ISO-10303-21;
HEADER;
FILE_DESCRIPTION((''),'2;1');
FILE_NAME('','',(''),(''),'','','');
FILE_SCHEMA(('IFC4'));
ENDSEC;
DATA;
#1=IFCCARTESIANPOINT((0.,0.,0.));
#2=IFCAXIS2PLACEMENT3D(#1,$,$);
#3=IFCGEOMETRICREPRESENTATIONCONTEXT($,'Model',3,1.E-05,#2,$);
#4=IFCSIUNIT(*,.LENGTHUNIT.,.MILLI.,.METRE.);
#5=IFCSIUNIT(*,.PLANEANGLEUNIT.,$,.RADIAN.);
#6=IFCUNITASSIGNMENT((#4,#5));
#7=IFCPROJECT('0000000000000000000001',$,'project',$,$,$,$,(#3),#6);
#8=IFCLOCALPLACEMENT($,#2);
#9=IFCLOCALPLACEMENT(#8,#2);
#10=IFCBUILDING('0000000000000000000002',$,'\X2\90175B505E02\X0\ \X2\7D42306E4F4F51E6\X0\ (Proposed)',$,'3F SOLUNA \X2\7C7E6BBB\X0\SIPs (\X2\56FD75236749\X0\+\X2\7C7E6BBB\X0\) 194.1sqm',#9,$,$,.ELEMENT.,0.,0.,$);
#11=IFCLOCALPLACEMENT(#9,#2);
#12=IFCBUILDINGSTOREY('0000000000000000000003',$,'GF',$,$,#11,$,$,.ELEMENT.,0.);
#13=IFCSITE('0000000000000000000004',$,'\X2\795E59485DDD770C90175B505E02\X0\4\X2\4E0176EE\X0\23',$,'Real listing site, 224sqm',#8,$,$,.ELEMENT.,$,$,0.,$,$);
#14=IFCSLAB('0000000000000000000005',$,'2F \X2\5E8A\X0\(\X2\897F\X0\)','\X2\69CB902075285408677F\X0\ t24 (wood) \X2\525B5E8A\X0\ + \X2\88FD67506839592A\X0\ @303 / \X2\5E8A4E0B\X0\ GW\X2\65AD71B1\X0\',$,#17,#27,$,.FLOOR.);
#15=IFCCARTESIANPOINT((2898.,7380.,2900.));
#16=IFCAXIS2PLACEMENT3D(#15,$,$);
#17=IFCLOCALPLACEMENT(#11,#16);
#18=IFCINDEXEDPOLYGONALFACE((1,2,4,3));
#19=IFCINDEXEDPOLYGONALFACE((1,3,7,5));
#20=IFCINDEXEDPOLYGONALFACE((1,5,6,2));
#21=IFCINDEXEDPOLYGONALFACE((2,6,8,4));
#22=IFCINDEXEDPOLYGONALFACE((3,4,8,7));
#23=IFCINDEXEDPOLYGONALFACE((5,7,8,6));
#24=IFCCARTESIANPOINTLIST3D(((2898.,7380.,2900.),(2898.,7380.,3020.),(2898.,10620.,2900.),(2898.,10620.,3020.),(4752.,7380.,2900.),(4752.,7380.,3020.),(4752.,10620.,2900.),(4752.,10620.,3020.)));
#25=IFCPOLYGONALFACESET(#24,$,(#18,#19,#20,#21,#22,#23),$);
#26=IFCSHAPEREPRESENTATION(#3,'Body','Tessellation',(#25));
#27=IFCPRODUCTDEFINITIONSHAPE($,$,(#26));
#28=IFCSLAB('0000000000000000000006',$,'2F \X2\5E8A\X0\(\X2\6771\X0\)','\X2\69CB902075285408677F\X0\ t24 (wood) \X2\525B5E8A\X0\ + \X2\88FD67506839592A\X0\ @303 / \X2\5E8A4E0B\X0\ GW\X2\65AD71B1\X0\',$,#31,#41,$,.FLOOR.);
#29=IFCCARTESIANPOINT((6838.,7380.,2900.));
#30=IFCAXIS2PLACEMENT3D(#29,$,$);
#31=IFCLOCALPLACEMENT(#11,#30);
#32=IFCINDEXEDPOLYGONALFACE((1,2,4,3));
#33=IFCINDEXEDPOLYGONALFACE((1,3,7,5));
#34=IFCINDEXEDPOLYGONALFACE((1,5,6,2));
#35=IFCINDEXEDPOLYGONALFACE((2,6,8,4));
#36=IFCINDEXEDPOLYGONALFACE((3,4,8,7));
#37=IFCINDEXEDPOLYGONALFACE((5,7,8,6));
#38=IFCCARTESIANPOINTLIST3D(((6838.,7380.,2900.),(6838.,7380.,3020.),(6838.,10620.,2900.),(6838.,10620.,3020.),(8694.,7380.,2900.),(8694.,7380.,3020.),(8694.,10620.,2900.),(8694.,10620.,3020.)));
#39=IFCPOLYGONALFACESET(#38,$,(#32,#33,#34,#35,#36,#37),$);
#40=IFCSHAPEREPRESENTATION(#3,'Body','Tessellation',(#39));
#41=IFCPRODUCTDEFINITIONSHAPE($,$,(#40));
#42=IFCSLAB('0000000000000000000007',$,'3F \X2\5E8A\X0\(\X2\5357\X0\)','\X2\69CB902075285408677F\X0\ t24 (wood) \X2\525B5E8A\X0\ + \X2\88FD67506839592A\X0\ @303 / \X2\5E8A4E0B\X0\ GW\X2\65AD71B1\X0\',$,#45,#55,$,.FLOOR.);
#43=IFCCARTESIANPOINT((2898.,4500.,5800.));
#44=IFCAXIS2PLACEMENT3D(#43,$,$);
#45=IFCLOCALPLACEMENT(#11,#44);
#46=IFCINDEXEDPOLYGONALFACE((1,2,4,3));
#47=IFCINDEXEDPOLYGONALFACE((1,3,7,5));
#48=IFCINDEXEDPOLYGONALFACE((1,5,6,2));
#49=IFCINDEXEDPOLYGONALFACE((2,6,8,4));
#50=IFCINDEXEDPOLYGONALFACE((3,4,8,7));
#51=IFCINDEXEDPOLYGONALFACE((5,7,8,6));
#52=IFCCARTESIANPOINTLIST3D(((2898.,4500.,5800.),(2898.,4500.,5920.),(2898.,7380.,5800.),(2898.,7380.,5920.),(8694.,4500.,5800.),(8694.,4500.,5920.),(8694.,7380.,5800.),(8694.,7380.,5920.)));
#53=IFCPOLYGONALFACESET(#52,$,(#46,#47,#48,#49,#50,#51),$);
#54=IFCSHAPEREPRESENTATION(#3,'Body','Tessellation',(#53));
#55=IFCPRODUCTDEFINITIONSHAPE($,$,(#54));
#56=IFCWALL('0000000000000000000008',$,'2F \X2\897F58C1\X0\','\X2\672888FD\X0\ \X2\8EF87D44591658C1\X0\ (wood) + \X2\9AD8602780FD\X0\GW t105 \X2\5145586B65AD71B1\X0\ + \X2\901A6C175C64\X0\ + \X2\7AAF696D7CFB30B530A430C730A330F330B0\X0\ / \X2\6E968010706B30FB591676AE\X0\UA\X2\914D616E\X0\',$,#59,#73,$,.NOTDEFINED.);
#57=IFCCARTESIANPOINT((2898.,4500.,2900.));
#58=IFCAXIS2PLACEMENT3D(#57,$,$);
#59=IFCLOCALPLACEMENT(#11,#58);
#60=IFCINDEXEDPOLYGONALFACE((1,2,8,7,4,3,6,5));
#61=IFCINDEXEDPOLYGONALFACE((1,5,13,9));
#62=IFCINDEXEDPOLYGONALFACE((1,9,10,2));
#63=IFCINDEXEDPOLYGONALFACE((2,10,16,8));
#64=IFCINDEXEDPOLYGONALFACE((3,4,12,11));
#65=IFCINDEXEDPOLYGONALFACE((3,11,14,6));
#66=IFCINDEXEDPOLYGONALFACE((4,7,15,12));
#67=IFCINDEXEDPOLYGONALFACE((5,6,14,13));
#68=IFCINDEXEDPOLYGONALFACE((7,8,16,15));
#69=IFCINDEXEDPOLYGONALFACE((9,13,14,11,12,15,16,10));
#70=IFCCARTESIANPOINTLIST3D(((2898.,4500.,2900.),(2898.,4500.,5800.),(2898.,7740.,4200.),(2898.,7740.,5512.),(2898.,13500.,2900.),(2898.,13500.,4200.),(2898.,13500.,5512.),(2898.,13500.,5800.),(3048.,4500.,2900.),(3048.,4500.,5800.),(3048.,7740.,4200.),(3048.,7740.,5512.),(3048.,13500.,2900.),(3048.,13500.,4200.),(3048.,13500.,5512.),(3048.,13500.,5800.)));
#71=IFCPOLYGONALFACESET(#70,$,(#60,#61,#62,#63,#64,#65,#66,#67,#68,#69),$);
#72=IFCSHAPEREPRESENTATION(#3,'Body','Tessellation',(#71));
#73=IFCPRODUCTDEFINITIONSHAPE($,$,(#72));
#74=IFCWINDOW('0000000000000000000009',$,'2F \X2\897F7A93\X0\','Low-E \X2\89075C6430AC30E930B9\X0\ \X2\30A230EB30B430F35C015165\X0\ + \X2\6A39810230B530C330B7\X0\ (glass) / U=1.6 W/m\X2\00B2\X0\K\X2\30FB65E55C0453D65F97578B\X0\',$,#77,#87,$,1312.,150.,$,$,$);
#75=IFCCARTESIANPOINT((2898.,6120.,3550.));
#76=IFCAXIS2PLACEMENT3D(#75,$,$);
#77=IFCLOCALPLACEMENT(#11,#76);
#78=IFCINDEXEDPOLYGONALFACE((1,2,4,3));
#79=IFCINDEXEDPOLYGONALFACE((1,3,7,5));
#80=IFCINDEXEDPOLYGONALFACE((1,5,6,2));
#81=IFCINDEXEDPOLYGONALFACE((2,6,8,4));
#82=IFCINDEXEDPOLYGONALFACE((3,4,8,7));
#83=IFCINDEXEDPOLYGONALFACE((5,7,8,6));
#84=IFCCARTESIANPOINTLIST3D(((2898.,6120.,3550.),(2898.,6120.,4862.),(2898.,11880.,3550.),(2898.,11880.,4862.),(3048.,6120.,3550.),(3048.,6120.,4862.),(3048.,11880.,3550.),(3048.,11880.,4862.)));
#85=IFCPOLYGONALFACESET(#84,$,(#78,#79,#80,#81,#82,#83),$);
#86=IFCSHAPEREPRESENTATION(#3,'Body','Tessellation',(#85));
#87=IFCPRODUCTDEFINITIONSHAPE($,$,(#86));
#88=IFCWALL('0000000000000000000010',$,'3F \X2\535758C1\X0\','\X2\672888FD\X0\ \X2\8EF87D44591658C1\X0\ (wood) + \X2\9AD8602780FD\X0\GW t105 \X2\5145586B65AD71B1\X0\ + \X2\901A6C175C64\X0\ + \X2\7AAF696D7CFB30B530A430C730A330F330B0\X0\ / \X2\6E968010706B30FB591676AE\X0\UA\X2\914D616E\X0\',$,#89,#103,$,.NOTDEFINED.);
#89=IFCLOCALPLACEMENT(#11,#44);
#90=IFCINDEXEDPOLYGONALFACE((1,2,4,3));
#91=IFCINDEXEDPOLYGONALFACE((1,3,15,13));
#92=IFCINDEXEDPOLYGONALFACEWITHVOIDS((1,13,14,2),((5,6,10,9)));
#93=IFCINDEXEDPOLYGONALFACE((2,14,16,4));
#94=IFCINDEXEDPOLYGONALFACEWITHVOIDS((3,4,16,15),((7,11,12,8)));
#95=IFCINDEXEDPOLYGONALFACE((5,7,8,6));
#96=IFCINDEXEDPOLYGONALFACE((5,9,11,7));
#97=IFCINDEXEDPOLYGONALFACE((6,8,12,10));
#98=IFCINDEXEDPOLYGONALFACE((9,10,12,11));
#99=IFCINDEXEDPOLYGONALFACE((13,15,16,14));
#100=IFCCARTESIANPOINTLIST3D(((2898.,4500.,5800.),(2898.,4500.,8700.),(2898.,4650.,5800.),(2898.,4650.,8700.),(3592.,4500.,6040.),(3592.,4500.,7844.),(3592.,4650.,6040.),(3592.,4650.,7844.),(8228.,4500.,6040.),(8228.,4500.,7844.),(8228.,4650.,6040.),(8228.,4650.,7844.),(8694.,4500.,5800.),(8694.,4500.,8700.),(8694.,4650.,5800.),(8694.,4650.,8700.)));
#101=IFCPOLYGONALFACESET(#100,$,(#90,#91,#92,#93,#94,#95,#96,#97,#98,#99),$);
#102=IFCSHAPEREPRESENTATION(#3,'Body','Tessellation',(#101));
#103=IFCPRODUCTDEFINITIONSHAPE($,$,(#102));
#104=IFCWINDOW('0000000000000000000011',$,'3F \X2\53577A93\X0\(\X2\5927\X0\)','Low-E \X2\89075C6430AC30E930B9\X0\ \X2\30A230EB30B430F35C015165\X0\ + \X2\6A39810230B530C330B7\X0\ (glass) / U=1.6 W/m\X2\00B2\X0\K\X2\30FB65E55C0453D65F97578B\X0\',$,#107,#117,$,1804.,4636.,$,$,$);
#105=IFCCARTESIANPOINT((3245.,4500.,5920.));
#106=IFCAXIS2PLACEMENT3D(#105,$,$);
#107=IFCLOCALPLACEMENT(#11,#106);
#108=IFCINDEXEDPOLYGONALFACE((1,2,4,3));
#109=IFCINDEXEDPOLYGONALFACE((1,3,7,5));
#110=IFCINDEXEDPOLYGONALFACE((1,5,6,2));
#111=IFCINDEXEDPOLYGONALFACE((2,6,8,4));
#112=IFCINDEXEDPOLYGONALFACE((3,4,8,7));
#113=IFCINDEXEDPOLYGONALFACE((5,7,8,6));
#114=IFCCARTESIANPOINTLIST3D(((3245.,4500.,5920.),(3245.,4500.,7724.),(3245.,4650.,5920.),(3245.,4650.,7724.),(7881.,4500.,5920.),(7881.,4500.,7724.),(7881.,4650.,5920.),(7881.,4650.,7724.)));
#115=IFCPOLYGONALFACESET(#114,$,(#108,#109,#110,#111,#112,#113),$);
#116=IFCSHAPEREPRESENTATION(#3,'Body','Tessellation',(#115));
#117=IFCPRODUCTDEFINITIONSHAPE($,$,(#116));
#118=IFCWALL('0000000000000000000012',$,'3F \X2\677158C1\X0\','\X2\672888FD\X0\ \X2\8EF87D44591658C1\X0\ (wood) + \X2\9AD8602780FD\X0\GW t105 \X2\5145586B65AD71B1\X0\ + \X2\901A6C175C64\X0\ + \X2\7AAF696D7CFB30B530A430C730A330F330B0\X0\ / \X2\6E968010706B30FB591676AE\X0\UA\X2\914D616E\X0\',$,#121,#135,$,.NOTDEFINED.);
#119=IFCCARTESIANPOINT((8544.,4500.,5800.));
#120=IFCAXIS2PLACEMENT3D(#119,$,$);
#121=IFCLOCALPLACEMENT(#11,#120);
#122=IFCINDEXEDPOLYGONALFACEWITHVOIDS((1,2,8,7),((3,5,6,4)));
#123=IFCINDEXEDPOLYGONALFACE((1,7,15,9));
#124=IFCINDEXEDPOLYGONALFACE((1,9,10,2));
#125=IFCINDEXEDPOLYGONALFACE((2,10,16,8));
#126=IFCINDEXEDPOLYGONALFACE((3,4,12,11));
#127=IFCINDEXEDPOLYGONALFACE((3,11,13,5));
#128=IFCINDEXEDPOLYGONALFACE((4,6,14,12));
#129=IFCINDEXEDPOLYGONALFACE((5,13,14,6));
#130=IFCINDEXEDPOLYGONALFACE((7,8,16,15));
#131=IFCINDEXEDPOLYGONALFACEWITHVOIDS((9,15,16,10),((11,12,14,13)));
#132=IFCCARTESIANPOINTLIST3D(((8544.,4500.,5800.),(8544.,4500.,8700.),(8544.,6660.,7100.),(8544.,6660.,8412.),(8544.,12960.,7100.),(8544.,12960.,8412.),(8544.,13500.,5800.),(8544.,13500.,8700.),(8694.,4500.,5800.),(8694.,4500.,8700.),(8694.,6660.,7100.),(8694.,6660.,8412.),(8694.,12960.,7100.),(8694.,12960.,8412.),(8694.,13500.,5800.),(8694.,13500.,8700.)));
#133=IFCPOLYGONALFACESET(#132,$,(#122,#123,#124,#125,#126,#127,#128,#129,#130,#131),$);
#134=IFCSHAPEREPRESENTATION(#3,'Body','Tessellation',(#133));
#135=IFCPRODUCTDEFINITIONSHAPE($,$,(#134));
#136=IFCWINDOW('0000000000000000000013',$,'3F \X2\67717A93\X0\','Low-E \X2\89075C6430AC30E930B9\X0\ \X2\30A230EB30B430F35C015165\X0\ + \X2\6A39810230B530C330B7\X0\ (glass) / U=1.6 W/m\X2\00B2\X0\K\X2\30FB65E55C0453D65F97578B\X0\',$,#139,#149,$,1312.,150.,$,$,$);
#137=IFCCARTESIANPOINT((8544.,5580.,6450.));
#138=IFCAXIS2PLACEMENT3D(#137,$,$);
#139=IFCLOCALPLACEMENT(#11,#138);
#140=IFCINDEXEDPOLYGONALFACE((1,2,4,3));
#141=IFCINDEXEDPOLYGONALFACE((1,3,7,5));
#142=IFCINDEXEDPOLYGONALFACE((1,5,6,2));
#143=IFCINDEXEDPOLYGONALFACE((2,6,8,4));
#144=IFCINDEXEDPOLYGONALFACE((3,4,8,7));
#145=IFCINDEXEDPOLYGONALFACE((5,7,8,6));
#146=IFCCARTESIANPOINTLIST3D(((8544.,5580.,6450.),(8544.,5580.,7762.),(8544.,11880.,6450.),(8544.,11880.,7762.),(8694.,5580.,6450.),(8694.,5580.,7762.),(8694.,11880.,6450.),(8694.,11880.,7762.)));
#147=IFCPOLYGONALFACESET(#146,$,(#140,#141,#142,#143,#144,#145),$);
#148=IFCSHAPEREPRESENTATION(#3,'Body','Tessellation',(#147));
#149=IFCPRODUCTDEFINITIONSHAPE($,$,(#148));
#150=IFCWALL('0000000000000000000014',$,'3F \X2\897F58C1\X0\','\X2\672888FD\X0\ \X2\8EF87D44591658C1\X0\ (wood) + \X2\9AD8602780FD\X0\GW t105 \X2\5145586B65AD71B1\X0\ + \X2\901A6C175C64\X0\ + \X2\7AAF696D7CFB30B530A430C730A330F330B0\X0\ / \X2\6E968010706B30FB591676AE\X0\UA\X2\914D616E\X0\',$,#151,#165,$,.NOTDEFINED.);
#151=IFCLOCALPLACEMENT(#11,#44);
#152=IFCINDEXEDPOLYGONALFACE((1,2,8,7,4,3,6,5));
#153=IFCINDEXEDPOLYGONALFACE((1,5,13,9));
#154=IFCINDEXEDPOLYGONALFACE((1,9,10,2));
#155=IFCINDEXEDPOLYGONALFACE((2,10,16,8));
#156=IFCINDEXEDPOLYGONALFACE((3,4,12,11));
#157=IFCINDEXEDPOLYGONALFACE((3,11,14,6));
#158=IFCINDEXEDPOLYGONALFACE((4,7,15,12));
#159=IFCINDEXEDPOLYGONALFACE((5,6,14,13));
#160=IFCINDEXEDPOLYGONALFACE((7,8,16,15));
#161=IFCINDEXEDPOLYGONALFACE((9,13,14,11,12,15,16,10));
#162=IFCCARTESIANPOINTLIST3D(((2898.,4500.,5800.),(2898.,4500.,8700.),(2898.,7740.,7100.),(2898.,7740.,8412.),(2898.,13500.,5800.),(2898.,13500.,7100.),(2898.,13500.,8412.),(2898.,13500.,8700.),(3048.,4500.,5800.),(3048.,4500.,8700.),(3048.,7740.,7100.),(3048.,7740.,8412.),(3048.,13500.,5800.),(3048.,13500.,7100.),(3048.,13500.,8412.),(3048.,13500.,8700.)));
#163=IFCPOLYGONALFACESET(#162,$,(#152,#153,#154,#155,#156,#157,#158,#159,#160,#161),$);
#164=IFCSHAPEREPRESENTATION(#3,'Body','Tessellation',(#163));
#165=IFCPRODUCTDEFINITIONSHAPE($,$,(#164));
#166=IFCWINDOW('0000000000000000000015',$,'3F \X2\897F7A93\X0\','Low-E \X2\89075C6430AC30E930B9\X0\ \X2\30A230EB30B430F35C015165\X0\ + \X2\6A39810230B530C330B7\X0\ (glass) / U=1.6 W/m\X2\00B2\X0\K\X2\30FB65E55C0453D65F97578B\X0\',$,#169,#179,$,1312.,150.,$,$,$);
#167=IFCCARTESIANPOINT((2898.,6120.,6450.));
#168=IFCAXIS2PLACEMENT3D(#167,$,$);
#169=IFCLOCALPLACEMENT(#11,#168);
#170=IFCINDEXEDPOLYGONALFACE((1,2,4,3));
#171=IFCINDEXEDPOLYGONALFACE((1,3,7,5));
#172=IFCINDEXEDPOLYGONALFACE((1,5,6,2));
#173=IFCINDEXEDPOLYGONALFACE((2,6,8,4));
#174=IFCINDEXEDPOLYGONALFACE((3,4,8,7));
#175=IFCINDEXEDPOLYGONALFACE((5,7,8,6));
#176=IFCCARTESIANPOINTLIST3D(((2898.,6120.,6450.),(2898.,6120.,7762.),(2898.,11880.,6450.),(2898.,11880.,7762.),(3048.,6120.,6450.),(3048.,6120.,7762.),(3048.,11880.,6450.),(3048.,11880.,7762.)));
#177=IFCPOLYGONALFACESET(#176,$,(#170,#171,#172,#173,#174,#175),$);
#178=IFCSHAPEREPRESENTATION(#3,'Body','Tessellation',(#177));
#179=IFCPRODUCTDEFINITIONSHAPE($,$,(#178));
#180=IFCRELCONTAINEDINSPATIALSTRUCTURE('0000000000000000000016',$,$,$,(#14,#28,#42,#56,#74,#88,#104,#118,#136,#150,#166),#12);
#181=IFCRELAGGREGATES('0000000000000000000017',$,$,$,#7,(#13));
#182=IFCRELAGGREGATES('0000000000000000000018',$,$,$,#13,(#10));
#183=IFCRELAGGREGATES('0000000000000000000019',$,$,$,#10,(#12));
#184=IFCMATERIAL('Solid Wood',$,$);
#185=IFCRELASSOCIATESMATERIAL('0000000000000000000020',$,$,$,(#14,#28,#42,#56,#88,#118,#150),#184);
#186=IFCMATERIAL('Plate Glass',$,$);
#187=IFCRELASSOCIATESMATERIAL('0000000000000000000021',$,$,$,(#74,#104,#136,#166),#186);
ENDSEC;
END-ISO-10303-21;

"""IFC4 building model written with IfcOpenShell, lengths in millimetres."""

from ifc_helpers import new_model, si_unit, frame, frame_2d, origin, place, context, project, spatial, rectangle, extrude, material, element, fill, save


model = new_model("IFC4")

# Units and contexts
model_context = context("Model", 3, precision=1e-05, world=origin())
ifc_project = project(units=[si_unit("LENGTHUNIT", "METRE", prefix="MILLI"), si_unit("PLANEANGLEUNIT", "RADIAN")], contexts=[model_context])

# Site, building, storey
site_placement = place(None, origin())
site = spatial("IfcSite", under=ifc_project, at=site_placement, Name="神奈川県逗子市4丁目23", ObjectType="Real listing site, 224sqm", CompositionType="ELEMENT", RefElevation=0.0)
building_placement = place(site_placement, origin())
building = spatial("IfcBuilding", under=site, at=building_placement, Name="逗子市 終の住処 (Proposed)", ObjectType="3F SOLUNA 籾殻SIPs (国産杉+籾殻) 194.1sqm", CompositionType="ELEMENT", ElevationOfRefHeight=0.0, ElevationOfTerrain=0.0)
storey_placement = place(building_placement, origin())
storey = spatial("IfcBuildingStorey", under=building, at=storey_placement, Name="GF", CompositionType="ELEMENT", Elevation=0.0)

# Slabs
ifc_material_1 = material(Name="Solid Wood")
slab_1_placement = place(storey_placement, frame((2898.0, 7380.0, 2900.0)))
element("IfcSlab", 1, at=slab_1_placement, inside=storey, material=ifc_material_1, Name="2F 床(西)", Description="構造用合板 t24 (wood) 剛床 + 製材根太 @303 / 床下 GW断熱", PredefinedType="FLOOR", context=model_context, shape_type="SweptSolid", body=[
    extrude(rectangle(XDim=1854.0, YDim=3240.0, at=frame_2d((927.0, 1620.0))), frame((2898.0, 7380.0, 2900.0)), (0.0, 0.0, 1.0), 120.0),
])
slab_2_placement = place(storey_placement, frame((6838.0, 7380.0, 2900.0)))
element("IfcSlab", 2, at=slab_2_placement, inside=storey, material=ifc_material_1, Name="2F 床(東)", Description="構造用合板 t24 (wood) 剛床 + 製材根太 @303 / 床下 GW断熱", PredefinedType="FLOOR", context=model_context, shape_type="SweptSolid", body=[
    extrude(rectangle(XDim=1856.0, YDim=3240.0, at=frame_2d((928.0, 1620.0))), frame((6838.0, 7380.0, 2900.0)), (0.0, 0.0, 1.0), 120.0),
])
slab_3_placement = place(storey_placement, frame((2898.0, 4500.0, 5800.0)))
element("IfcSlab", 3, at=slab_3_placement, inside=storey, material=ifc_material_1, Name="3F 床(南)", Description="構造用合板 t24 (wood) 剛床 + 製材根太 @303 / 床下 GW断熱", PredefinedType="FLOOR", context=model_context, shape_type="SweptSolid", body=[
    extrude(rectangle(XDim=5796.0, YDim=2880.0, at=frame_2d((2898.0, 1440.0))), frame((2898.0, 4500.0, 5800.0)), (0.0, 0.0, 1.0), 120.0),
])

# Walls, openings, windows
wall_1_placement = place(storey_placement, frame((2898.0, 4500.0, 2900.0)))
wall_1 = element("IfcWall", 4, at=wall_1_placement, inside=storey, material=ifc_material_1, Name="2F 西壁", Description="木製 軸組外壁 (wood) + 高性能GW t105 充填断熱 + 通気層 + 窯業系サイディング / 準耐火・外皮UA配慮", PredefinedType="NOTDEFINED", context=model_context, shape_type="SweptSolid", body=[
    extrude(rectangle(XDim=150.0, YDim=9000.0, at=frame_2d((75.0, 4500.0))), frame((2898.0, 4500.0, 2900.0)), (0.0, 0.0, 1.0), 2900.0),
])
opening_1_placement = place(storey_placement, frame((2898.0, 6120.0, 3550.0)))
opening_1 = element("IfcOpeningElement", 5, at=opening_1_placement, cuts=wall_1, PredefinedType="NOTDEFINED", context=model_context, shape_type="SweptSolid", body=[
    extrude(rectangle(XDim=150.0, YDim=5760.0, at=frame_2d((75.0, 2880.0))), frame((2898.0, 6120.0, 3550.0)), (0.0, 0.0, 1.0), 1312.0),
])
ifc_material_2 = material(Name="Plate Glass")
window_1_placement = place(storey_placement, frame((2898.0, 6120.0, 3550.0)))
window_1 = element("IfcWindow", 6, at=window_1_placement, inside=storey, material=ifc_material_2, Name="2F 西窓", Description="Low-E 複層ガラス アルゴン封入 + 樹脂サッシ (glass) / U=1.6 W/m²K・日射取得型", OverallHeight=1312.0, OverallWidth=150.0, context=model_context, shape_type="SweptSolid", body=[
    extrude(rectangle(XDim=150.0, YDim=5760.0, at=frame_2d((75.0, 2880.0))), frame((2898.0, 6120.0, 3550.0)), (0.0, 0.0, 1.0), 1312.0),
])
fill(opening_1, window_1)
wall_2_placement = place(storey_placement, frame((2898.0, 4500.0, 5800.0)))
wall_2 = element("IfcWall", 7, at=wall_2_placement, inside=storey, material=ifc_material_1, Name="3F 南壁", Description="木製 軸組外壁 (wood) + 高性能GW t105 充填断熱 + 通気層 + 窯業系サイディング / 準耐火・外皮UA配慮", PredefinedType="NOTDEFINED", context=model_context, shape_type="SweptSolid", body=[
    extrude(rectangle(XDim=5796.0, YDim=150.0, at=frame_2d((2898.0, 75.0))), frame((2898.0, 4500.0, 5800.0)), (0.0, 0.0, 1.0), 2900.0),
])
opening_2_placement = place(storey_placement, frame((3245.0, 4500.0, 5920.0)))
opening_2 = element("IfcOpeningElement", 8, at=opening_2_placement, cuts=wall_2, PredefinedType="NOTDEFINED", context=model_context, shape_type="SweptSolid", body=[
    extrude(rectangle(XDim=4636.0, YDim=150.0, at=frame_2d((2318.0, 75.0))), frame((3245.0, 4500.0, 5920.0)), (0.0, 0.0, 1.0), 1804.0),
])
window_2_placement = place(storey_placement, frame((3245.0, 4500.0, 5920.0)))
window_2 = element("IfcWindow", 9, at=window_2_placement, inside=storey, material=ifc_material_2, Name="3F 南窓(大)", Description="Low-E 複層ガラス アルゴン封入 + 樹脂サッシ (glass) / U=1.6 W/m²K・日射取得型", OverallHeight=1804.0, OverallWidth=4636.0, context=model_context, shape_type="SweptSolid", body=[
    extrude(rectangle(XDim=4636.0, YDim=150.0, at=frame_2d((2318.0, 75.0))), frame((3245.0, 4500.0, 5920.0)), (0.0, 0.0, 1.0), 1804.0),
])
fill(opening_2, window_2)
wall_3_placement = place(storey_placement, frame((8544.0, 4500.0, 5800.0)))
wall_3 = element("IfcWall", 10, at=wall_3_placement, inside=storey, material=ifc_material_1, Name="3F 東壁", Description="木製 軸組外壁 (wood) + 高性能GW t105 充填断熱 + 通気層 + 窯業系サイディング / 準耐火・外皮UA配慮", PredefinedType="NOTDEFINED", context=model_context, shape_type="SweptSolid", body=[
    extrude(rectangle(XDim=150.0, YDim=9000.0, at=frame_2d((75.0, 4500.0))), frame((8544.0, 4500.0, 5800.0)), (0.0, 0.0, 1.0), 2900.0),
])
opening_3_placement = place(storey_placement, frame((8544.0, 5580.0, 6450.0)))
opening_3 = element("IfcOpeningElement", 11, at=opening_3_placement, cuts=wall_3, PredefinedType="NOTDEFINED", context=model_context, shape_type="SweptSolid", body=[
    extrude(rectangle(XDim=150.0, YDim=6300.0, at=frame_2d((75.0, 3150.0))), frame((8544.0, 5580.0, 6450.0)), (0.0, 0.0, 1.0), 1312.0),
])
window_3_placement = place(storey_placement, frame((8544.0, 5580.0, 6450.0)))
window_3 = element("IfcWindow", 12, at=window_3_placement, inside=storey, material=ifc_material_2, Name="3F 東窓", Description="Low-E 複層ガラス アルゴン封入 + 樹脂サッシ (glass) / U=1.6 W/m²K・日射取得型", OverallHeight=1312.0, OverallWidth=150.0, context=model_context, shape_type="SweptSolid", body=[
    extrude(rectangle(XDim=150.0, YDim=6300.0, at=frame_2d((75.0, 3150.0))), frame((8544.0, 5580.0, 6450.0)), (0.0, 0.0, 1.0), 1312.0),
])
fill(opening_3, window_3)
wall_4_placement = place(storey_placement, frame((2898.0, 4500.0, 5800.0)))
wall_4 = element("IfcWall", 13, at=wall_4_placement, inside=storey, material=ifc_material_1, Name="3F 西壁", Description="木製 軸組外壁 (wood) + 高性能GW t105 充填断熱 + 通気層 + 窯業系サイディング / 準耐火・外皮UA配慮", PredefinedType="NOTDEFINED", context=model_context, shape_type="SweptSolid", body=[
    extrude(rectangle(XDim=150.0, YDim=9000.0, at=frame_2d((75.0, 4500.0))), frame((2898.0, 4500.0, 5800.0)), (0.0, 0.0, 1.0), 2900.0),
])
opening_4_placement = place(storey_placement, frame((2898.0, 6120.0, 6450.0)))
opening_4 = element("IfcOpeningElement", 14, at=opening_4_placement, cuts=wall_4, PredefinedType="NOTDEFINED", context=model_context, shape_type="SweptSolid", body=[
    extrude(rectangle(XDim=150.0, YDim=5760.0, at=frame_2d((75.0, 2880.0))), frame((2898.0, 6120.0, 6450.0)), (0.0, 0.0, 1.0), 1312.0),
])
window_4_placement = place(storey_placement, frame((2898.0, 6120.0, 6450.0)))
window_4 = element("IfcWindow", 15, at=window_4_placement, inside=storey, material=ifc_material_2, Name="3F 西窓", Description="Low-E 複層ガラス アルゴン封入 + 樹脂サッシ (glass) / U=1.6 W/m²K・日射取得型", OverallHeight=1312.0, OverallWidth=150.0, context=model_context, shape_type="SweptSolid", body=[
    extrude(rectangle(XDim=150.0, YDim=5760.0, at=frame_2d((75.0, 2880.0))), frame((2898.0, 6120.0, 6450.0)), (0.0, 0.0, 1.0), 1312.0),
])
fill(opening_4, window_4)

save(model, "model.ifc")
